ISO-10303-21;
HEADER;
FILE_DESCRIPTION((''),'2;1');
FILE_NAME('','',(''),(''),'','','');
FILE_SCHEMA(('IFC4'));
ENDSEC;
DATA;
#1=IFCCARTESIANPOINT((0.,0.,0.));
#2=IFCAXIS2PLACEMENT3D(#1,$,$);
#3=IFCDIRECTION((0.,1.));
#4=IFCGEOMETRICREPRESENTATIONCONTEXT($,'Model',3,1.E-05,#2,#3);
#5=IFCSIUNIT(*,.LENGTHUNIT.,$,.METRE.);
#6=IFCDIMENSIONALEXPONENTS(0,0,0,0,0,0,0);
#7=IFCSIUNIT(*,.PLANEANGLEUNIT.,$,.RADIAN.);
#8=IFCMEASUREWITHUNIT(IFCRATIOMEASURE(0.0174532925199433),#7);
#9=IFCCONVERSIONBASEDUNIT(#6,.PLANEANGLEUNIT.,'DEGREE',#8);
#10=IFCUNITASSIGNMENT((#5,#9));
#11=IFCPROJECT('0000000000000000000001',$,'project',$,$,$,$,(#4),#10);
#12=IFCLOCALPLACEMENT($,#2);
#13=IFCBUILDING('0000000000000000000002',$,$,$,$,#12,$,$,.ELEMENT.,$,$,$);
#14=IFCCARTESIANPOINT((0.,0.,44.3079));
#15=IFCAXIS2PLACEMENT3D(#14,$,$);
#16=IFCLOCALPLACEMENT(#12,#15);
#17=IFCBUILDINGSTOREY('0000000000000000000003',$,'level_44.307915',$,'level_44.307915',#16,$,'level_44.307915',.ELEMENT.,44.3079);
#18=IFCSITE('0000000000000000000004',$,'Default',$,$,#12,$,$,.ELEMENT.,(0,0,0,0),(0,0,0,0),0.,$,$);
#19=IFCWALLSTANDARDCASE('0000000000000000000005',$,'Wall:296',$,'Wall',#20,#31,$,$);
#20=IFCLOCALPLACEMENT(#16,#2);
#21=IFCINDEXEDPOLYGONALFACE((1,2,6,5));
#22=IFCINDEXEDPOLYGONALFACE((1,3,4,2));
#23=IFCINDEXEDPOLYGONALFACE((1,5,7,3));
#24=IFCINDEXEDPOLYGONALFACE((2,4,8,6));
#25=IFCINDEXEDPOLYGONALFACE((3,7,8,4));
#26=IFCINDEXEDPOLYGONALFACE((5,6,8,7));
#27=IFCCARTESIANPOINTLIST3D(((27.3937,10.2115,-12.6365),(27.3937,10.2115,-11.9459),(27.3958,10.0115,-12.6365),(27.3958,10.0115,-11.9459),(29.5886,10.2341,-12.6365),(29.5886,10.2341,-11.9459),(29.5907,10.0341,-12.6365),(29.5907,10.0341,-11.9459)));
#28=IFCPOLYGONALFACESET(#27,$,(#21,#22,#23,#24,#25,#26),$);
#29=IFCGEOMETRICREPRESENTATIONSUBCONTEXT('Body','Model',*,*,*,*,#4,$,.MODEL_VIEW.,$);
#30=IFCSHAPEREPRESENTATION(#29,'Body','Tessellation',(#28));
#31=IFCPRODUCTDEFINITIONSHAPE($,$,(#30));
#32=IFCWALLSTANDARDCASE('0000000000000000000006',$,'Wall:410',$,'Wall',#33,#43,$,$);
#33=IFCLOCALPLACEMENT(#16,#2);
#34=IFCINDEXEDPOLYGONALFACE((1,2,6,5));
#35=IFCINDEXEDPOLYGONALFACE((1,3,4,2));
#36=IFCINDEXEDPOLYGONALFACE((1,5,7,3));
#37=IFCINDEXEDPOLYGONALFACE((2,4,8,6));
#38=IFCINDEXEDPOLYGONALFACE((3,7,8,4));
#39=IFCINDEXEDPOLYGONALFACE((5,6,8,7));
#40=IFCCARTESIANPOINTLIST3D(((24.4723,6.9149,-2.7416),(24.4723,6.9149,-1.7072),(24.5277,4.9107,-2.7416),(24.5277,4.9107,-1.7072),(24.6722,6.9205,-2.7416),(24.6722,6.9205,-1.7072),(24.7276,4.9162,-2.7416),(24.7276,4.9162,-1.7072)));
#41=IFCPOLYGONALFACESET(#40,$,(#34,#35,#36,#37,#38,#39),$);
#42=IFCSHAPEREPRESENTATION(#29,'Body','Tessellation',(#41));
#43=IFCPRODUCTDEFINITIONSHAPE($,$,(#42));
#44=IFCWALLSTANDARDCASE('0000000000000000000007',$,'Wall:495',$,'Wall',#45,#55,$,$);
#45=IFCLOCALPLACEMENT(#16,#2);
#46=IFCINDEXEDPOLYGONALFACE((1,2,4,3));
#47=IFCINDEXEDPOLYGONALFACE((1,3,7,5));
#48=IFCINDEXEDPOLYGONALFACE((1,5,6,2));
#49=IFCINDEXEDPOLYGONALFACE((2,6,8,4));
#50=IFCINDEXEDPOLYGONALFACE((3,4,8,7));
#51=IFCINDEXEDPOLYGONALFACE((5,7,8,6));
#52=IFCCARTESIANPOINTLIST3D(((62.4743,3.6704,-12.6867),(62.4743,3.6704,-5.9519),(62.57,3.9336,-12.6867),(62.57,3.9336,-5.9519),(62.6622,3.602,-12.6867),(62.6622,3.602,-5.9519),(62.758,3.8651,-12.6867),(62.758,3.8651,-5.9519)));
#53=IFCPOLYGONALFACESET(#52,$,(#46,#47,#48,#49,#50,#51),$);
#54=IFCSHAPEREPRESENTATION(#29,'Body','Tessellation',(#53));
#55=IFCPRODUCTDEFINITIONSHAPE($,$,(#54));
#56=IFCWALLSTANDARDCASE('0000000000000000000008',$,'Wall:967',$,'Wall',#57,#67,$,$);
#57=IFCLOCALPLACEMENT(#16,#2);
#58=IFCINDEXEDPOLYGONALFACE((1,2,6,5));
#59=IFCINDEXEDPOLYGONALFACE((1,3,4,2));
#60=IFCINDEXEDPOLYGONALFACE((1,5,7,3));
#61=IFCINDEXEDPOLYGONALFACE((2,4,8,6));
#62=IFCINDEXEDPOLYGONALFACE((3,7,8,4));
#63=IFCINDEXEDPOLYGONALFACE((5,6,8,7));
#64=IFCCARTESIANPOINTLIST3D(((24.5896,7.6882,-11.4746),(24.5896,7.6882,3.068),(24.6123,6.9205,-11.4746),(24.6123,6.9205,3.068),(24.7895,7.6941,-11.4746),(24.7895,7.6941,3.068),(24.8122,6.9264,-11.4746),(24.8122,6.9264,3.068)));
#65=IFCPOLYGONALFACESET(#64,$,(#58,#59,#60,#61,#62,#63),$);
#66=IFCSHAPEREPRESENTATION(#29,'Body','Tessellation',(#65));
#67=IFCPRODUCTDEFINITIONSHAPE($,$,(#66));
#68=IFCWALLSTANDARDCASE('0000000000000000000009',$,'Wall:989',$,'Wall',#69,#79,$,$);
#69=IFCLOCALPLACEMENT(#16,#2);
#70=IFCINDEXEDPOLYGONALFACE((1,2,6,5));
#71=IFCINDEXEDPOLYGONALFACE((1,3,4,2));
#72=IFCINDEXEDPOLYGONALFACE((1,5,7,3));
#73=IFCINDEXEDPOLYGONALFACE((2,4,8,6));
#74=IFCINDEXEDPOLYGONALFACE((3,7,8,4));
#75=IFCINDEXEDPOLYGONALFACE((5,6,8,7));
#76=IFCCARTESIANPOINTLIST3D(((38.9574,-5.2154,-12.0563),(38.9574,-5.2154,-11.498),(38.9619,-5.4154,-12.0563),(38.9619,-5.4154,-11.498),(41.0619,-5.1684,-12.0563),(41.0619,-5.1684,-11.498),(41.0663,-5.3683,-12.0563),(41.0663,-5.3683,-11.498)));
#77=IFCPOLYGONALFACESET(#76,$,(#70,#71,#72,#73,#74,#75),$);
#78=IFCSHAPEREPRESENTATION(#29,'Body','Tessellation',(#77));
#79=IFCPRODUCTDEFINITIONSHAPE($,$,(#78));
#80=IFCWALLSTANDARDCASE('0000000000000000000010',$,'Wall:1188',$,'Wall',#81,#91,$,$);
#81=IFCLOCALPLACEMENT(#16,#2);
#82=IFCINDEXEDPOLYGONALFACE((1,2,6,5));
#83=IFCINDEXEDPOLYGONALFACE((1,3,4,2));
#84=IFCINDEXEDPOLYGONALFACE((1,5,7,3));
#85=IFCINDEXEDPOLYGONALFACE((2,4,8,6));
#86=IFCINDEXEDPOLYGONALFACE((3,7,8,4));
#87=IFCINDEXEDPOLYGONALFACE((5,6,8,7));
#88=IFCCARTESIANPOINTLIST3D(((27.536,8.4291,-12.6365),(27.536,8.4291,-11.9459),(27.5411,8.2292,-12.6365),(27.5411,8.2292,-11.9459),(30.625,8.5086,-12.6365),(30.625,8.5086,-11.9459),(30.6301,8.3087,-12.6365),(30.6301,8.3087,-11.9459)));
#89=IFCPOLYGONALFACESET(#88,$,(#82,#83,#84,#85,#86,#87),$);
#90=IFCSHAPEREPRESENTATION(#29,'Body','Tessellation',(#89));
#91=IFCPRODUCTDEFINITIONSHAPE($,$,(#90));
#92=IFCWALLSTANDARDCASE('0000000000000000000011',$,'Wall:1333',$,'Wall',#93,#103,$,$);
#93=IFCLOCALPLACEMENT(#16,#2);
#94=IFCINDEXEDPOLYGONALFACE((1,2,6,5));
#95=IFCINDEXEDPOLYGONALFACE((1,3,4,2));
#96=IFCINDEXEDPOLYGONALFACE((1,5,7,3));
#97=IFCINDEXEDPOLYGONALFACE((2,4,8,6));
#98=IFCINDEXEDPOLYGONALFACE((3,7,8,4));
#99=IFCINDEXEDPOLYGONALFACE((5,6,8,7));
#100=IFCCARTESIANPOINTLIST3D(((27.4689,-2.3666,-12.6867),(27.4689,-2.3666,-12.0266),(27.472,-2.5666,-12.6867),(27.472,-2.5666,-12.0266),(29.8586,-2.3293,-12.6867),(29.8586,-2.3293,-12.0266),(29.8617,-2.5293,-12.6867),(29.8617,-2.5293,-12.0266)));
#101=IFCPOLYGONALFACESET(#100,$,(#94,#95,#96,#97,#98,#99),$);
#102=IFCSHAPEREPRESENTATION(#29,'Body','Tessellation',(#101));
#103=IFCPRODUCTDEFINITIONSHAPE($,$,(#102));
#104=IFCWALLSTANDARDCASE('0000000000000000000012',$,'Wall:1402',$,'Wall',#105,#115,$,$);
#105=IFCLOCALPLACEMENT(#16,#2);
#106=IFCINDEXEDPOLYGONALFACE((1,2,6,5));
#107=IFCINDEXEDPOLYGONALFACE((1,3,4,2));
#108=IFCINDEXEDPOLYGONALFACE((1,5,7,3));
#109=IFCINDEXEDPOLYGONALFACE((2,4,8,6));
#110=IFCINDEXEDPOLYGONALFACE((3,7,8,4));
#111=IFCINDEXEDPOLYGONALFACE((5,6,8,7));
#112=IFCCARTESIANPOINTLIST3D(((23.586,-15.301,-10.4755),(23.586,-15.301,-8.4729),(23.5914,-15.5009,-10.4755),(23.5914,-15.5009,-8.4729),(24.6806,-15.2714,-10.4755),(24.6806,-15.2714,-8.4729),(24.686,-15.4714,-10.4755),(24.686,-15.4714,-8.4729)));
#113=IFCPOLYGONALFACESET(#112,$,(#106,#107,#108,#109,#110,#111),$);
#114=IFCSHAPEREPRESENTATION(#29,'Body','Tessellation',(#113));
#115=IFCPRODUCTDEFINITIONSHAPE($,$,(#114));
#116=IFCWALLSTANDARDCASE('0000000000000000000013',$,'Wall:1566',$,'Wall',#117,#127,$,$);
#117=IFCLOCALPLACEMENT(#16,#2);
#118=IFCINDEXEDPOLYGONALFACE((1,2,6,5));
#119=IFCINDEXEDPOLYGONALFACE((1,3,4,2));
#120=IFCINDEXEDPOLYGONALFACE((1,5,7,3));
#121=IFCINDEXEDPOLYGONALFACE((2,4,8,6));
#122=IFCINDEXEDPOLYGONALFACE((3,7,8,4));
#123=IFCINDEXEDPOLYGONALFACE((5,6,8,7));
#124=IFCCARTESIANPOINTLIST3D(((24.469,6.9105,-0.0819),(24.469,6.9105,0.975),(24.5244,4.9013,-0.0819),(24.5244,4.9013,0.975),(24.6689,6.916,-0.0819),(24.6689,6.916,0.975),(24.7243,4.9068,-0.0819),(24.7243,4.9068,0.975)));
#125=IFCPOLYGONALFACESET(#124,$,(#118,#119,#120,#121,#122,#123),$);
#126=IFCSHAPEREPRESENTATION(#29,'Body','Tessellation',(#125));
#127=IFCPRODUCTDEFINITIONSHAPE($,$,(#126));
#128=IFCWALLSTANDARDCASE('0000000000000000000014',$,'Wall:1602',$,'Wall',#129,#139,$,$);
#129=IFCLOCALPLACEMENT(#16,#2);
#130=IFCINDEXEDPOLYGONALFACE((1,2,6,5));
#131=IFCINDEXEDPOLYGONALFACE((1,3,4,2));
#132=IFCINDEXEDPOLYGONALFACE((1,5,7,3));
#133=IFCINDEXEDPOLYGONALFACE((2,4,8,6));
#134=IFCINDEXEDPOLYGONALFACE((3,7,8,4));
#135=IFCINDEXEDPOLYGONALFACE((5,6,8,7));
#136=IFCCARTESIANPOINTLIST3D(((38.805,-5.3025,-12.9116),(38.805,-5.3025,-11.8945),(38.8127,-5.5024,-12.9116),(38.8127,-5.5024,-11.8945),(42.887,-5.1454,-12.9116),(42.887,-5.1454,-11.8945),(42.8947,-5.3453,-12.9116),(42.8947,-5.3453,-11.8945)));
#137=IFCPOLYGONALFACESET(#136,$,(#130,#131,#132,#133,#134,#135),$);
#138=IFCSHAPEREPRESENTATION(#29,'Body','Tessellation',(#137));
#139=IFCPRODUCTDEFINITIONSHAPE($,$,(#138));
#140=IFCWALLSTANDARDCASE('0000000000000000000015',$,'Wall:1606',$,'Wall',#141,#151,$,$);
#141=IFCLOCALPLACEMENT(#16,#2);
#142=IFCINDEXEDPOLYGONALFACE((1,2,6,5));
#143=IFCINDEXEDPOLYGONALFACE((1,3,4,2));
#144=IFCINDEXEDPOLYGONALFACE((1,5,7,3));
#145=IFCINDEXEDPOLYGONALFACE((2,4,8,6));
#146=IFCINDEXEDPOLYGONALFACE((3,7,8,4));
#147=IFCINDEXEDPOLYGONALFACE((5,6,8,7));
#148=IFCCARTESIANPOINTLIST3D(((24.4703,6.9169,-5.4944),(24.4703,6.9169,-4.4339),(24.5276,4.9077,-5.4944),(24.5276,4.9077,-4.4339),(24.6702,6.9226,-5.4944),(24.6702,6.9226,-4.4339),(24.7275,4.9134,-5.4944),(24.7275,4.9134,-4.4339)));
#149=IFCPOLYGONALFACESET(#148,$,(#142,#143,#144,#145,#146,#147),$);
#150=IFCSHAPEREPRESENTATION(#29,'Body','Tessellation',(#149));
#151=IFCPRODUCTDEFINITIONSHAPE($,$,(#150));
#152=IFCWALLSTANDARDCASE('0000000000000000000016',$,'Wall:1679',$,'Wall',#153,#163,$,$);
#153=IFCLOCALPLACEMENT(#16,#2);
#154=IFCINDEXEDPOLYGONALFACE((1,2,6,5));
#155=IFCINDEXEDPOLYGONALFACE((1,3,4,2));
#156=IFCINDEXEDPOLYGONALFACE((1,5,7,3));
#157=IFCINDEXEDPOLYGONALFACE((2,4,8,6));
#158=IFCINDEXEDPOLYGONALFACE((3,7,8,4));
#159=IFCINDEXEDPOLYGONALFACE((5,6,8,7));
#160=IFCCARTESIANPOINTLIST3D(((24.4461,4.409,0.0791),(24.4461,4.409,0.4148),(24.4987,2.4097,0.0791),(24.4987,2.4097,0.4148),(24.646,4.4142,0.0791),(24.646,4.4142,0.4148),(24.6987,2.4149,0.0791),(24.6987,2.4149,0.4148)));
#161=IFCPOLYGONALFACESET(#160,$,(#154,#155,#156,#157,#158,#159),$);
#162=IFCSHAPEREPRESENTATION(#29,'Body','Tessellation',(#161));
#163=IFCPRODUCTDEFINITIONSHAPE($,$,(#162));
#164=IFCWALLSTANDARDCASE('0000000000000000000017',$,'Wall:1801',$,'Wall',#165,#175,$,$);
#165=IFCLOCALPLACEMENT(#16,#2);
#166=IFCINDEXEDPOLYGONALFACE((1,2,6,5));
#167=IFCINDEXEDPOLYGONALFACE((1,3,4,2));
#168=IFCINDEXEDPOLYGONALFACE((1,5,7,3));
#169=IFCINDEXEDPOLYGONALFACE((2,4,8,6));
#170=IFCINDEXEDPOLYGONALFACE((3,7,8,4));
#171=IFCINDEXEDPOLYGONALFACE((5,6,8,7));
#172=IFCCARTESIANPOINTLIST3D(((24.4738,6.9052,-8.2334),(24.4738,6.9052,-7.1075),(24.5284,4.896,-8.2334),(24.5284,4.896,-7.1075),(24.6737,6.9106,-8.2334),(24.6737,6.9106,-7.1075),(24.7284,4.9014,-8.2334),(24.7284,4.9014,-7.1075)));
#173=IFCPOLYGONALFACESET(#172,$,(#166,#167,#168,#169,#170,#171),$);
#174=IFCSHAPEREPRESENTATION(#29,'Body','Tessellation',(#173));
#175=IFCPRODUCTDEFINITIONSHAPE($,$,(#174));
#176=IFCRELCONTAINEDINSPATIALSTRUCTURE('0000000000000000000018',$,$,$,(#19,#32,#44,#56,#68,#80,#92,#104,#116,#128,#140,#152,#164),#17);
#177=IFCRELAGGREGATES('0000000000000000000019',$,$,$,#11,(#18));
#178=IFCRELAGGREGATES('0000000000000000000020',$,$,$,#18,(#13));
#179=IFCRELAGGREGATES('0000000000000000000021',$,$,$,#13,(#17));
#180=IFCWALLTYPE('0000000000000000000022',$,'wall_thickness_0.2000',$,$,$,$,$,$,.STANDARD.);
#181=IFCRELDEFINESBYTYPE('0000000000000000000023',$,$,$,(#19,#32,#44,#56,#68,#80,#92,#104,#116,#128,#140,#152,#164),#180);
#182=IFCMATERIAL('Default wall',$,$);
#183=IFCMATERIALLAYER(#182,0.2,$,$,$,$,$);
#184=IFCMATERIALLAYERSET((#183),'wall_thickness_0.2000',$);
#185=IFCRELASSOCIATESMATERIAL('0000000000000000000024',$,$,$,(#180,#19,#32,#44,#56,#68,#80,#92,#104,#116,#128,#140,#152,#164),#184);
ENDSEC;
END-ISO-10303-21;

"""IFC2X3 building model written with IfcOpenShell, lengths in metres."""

from ifc_helpers import new_model, entity, si_unit, converted_unit, direction, frame, origin, place, context, subcontext, project, spatial, polyline, outline, extrude, material, layer, layer_set, layer_usage, type_object, element, save


model = new_model("IFC2X3")

# Units and contexts
model_context = context("Model", 3, precision=1e-05, world=origin(), true_north=direction((0.0, 1.0)))
body_context = subcontext(model_context, "Body", "Model", "MODEL_VIEW")
ifc_project = project(units=[si_unit("LENGTHUNIT", "METRE"), converted_unit("PLANEANGLEUNIT", "DEGREE", entity("IfcRatioMeasure", 0.0174532925199433), si_unit("PLANEANGLEUNIT", "RADIAN"), dimensions=[0, 0, 0, 0, 0, 0, 0])], contexts=[model_context])

# Site, building, storey
placement_1 = place(None, origin())
site = spatial("IfcSite", under=ifc_project, at=placement_1, Name="Default", CompositionType="ELEMENT", RefLatitude=(0, 0, 0, 0), RefLongitude=(0, 0, 0, 0), RefElevation=0.0)
building = spatial("IfcBuilding", under=site, at=placement_1, CompositionType="ELEMENT")
storey_placement = place(placement_1, frame((0.0, 0.0, 44.3079)))
storey = spatial("IfcBuildingStorey", under=building, at=storey_placement, Name="level_44.307915", ObjectType="level_44.307915", LongName="level_44.307915", CompositionType="ELEMENT", Elevation=44.3079)

# Walls
ifc_material_1 = material(Name="Default wall")
ifc_layer = layer(ifc_material_1, 0.2)
ifc_layer_set = layer_set([ifc_layer], Name="wall_thickness_0.2000")
ifc_layer_usage = layer_usage(ifc_layer_set, "AXIS2", "POSITIVE", -0.1)
wall_type = type_object("IfcWallType", Name="wall_thickness_0.2000", PredefinedType="STANDARD", material=ifc_layer_set)
placement_2 = place(placement_1, frame((0.0, 0.0, 31.6714)))
wall_1_placement = place(placement_2, frame((27.3948, 10.1115, 0.0), z_axis=(0.0, 0.0, 1.0), x_axis=(0.999947, 0.010312, 0.0)))
element("IfcWallStandardCase", 1, at=wall_1_placement, inside=storey, type_object=wall_type, material=ifc_layer_usage, Name="Wall:296", ObjectType="Wall", context=body_context, shape_type="SweptSolid", body=[
    extrude(outline(polyline([(2.195, -0.1), (2.195, 0.1), (0.0, 0.1), (0.0, -0.1), (2.195, -0.1)])), origin(), (0.0, 0.0, 1.0), 0.6906),
])
placement_3 = place(placement_1, frame((0.0, 0.0, 41.5663)))
wall_2_placement = place(placement_3, frame((24.6276, 4.9135, 0.0), z_axis=(0.0, 0.0, 1.0), x_axis=(-0.027649, 0.999618, 0.0)))
element("IfcWallStandardCase", 2, at=wall_2_placement, inside=storey, type_object=wall_type, material=ifc_layer_usage, Name="Wall:410", ObjectType="Wall", context=body_context, shape_type="SweptSolid", body=[
    extrude(outline(polyline([(2.005, -0.1), (2.005, 0.1), (0.0, 0.1), (0.0, -0.1), (2.005, -0.1)])), origin(), (0.0, 0.0, 1.0), 1.0344),
])
placement_4 = place(placement_1, frame((0.0, 0.0, 31.6212)))
wall_3_placement = place(placement_4, frame((62.664, 3.8993, 0.0), z_axis=(0.0, 0.0, 1.0), x_axis=(-0.342096, -0.939665, 0.0)))
element("IfcWallStandardCase", 3, at=wall_3_placement, inside=storey, type_object=wall_type, material=ifc_layer_usage, Name="Wall:495", ObjectType="Wall", context=body_context, shape_type="SweptSolid", body=[
    extrude(outline(polyline([(0.28, -0.1), (0.28, 0.1), (0.0, 0.1), (0.0, -0.1), (0.28, -0.1)])), origin(), (0.0, 0.0, 1.0), 6.7348),
])
placement_5 = place(placement_1, frame((0.0, 0.0, 32.8333)))
wall_4_placement = place(placement_5, frame((24.6895, 7.6911, 0.0), z_axis=(0.0, 0.0, 1.0), x_axis=(0.029652, -0.99956, 0.0)))
element("IfcWallStandardCase", 4, at=wall_4_placement, inside=storey, type_object=wall_type, material=ifc_layer_usage, Name="Wall:967", ObjectType="Wall", context=body_context, shape_type="SweptSolid", body=[
    extrude(outline(polyline([(0.768, -0.1), (0.768, 0.1), (0.0, 0.1), (0.0, -0.1), (0.768, -0.1)])), origin(), (0.0, 0.0, 1.0), 14.5426),
])
placement_6 = place(placement_1, frame((0.0, 0.0, 32.2516)))
wall_5_placement = place(placement_6, frame((38.9596, -5.3154, 0.0), z_axis=(0.0, 0.0, 1.0), x_axis=(0.99975, 0.022366, 0.0)))
element("IfcWallStandardCase", 5, at=wall_5_placement, inside=storey, type_object=wall_type, material=ifc_layer_usage, Name="Wall:989", ObjectType="Wall", context=body_context, shape_type="SweptSolid", body=[
    extrude(outline(polyline([(2.105, -0.1), (2.105, 0.1), (0.0, 0.1), (0.0, -0.1), (2.105, -0.1)])), origin(), (0.0, 0.0, 1.0), 0.5583),
])
placement_7 = place(placement_1, frame((0.0, 0.0, 31.6714)))
wall_6_placement = place(placement_7, frame((27.5386, 8.3291, 0.0), z_axis=(0.0, 0.0, 1.0), x_axis=(0.999669, 0.025741, 0.0)))
element("IfcWallStandardCase", 6, at=wall_6_placement, inside=storey, type_object=wall_type, material=ifc_layer_usage, Name="Wall:1188", ObjectType="Wall", context=body_context, shape_type="SweptSolid", body=[
    extrude(outline(polyline([(3.09, -0.1), (3.09, 0.1), (0.0, 0.1), (0.0, -0.1), (3.09, -0.1)])), origin(), (0.0, 0.0, 1.0), 0.6906),
])
placement_8 = place(placement_1, frame((0.0, 0.0, 31.6212)))
wall_7_placement = place(placement_8, frame((27.4705, -2.4666, 0.0), z_axis=(0.0, 0.0, 1.0), x_axis=(0.999878, 0.015604, 0.0)))
element("IfcWallStandardCase", 7, at=wall_7_placement, inside=storey, type_object=wall_type, material=ifc_layer_usage, Name="Wall:1333", ObjectType="Wall", context=body_context, shape_type="SweptSolid", body=[
    extrude(outline(polyline([(2.39, -0.1), (2.39, 0.1), (0.0, 0.1), (0.0, -0.1), (2.39, -0.1)])), origin(), (0.0, 0.0, 1.0), 0.6601),
])
placement_9 = place(placement_1, frame((0.0, 0.0, 33.8324)))
wall_8_placement = place(placement_9, frame((24.6833, -15.3714, 0.0), z_axis=(0.0, 0.0, 1.0), x_axis=(-0.999635, -0.027018, 0.0)))
element("IfcWallStandardCase", 8, at=wall_8_placement, inside=storey, type_object=wall_type, material=ifc_layer_usage, Name="Wall:1402", ObjectType="Wall", context=body_context, shape_type="SweptSolid", body=[
    extrude(outline(polyline([(1.095, -0.1), (1.095, 0.1), (0.0, 0.1), (0.0, -0.1), (1.095, -0.1)])), origin(), (0.0, 0.0, 1.0), 2.0025),
])
placement_10 = place(placement_1, frame((0.0, 0.0, 44.226)))
wall_9_placement = place(placement_10, frame((24.6244, 4.904, 0.0), z_axis=(0.0, 0.0, 1.0), x_axis=(-0.027582, 0.99962, 0.0)))
element("IfcWallStandardCase", 9, at=wall_9_placement, inside=storey, type_object=wall_type, material=ifc_layer_usage, Name="Wall:1566", ObjectType="Wall", context=body_context, shape_type="SweptSolid", body=[
    extrude(outline(polyline([(2.01, -0.1), (2.01, 0.1), (0.0, 0.1), (0.0, -0.1), (2.01, -0.1)])), origin(), (0.0, 0.0, 1.0), 1.0569),
])
placement_11 = place(placement_1, frame((0.0, 0.0, 31.3963)))
wall_10_placement = place(placement_11, frame((38.8089, -5.4025, 0.0), z_axis=(0.0, 0.0, 1.0), x_axis=(0.99926, 0.038461, 0.0)))
element("IfcWallStandardCase", 10, at=wall_10_placement, inside=storey, type_object=wall_type, material=ifc_layer_usage, Name="Wall:1602", ObjectType="Wall", context=body_context, shape_type="SweptSolid", body=[
    extrude(outline(polyline([(4.085, -0.1), (4.085, 0.1), (0.0, 0.1), (0.0, -0.1), (4.085, -0.1)])), origin(), (0.0, 0.0, 1.0), 1.0171),
])
placement_12 = place(placement_1, frame((0.0, 0.0, 38.8135)))
wall_11_placement = place(placement_12, frame((24.6276, 4.9106, 0.0), z_axis=(0.0, 0.0, 1.0), x_axis=(-0.028513, 0.999593, 0.0)))
element("IfcWallStandardCase", 11, at=wall_11_placement, inside=storey, type_object=wall_type, material=ifc_layer_usage, Name="Wall:1606", ObjectType="Wall", context=body_context, shape_type="SweptSolid", body=[
    extrude(outline(polyline([(2.01, -0.1), (2.01, 0.1), (0.0, 0.1), (0.0, -0.1), (2.01, -0.1)])), origin(), (0.0, 0.0, 1.0), 1.0605),
])
placement_13 = place(placement_1, frame((0.0, 0.0, 44.387)))
wall_12_placement = place(placement_13, frame((24.5461, 4.4116, 0.0), z_axis=(0.0, 0.0, 1.0), x_axis=(0.026318, -0.999654, 0.0)))
element("IfcWallStandardCase", 12, at=wall_12_placement, inside=storey, type_object=wall_type, material=ifc_layer_usage, Name="Wall:1679", ObjectType="Wall", context=body_context, shape_type="SweptSolid", body=[
    extrude(outline(polyline([(2.0, -0.1), (2.0, 0.1), (0.0, 0.1), (0.0, -0.1), (2.0, -0.1)])), origin(), (0.0, 0.0, 1.0), 0.3356),
])
placement_14 = place(placement_1, frame((0.0, 0.0, 36.0745)))
wall_13_placement = place(placement_14, frame((24.6284, 4.8987, 0.0), z_axis=(0.0, 0.0, 1.0), x_axis=(-0.027193, 0.99963, 0.0)))
element("IfcWallStandardCase", 13, at=wall_13_placement, inside=storey, type_object=wall_type, material=ifc_layer_usage, Name="Wall:1801", ObjectType="Wall", context=body_context, shape_type="SweptSolid", body=[
    extrude(outline(polyline([(2.01, -0.1), (2.01, 0.1), (0.0, 0.1), (0.0, -0.1), (2.01, -0.1)])), origin(), (0.0, 0.0, 1.0), 1.1259),
])

save(model, "model.ifc")
